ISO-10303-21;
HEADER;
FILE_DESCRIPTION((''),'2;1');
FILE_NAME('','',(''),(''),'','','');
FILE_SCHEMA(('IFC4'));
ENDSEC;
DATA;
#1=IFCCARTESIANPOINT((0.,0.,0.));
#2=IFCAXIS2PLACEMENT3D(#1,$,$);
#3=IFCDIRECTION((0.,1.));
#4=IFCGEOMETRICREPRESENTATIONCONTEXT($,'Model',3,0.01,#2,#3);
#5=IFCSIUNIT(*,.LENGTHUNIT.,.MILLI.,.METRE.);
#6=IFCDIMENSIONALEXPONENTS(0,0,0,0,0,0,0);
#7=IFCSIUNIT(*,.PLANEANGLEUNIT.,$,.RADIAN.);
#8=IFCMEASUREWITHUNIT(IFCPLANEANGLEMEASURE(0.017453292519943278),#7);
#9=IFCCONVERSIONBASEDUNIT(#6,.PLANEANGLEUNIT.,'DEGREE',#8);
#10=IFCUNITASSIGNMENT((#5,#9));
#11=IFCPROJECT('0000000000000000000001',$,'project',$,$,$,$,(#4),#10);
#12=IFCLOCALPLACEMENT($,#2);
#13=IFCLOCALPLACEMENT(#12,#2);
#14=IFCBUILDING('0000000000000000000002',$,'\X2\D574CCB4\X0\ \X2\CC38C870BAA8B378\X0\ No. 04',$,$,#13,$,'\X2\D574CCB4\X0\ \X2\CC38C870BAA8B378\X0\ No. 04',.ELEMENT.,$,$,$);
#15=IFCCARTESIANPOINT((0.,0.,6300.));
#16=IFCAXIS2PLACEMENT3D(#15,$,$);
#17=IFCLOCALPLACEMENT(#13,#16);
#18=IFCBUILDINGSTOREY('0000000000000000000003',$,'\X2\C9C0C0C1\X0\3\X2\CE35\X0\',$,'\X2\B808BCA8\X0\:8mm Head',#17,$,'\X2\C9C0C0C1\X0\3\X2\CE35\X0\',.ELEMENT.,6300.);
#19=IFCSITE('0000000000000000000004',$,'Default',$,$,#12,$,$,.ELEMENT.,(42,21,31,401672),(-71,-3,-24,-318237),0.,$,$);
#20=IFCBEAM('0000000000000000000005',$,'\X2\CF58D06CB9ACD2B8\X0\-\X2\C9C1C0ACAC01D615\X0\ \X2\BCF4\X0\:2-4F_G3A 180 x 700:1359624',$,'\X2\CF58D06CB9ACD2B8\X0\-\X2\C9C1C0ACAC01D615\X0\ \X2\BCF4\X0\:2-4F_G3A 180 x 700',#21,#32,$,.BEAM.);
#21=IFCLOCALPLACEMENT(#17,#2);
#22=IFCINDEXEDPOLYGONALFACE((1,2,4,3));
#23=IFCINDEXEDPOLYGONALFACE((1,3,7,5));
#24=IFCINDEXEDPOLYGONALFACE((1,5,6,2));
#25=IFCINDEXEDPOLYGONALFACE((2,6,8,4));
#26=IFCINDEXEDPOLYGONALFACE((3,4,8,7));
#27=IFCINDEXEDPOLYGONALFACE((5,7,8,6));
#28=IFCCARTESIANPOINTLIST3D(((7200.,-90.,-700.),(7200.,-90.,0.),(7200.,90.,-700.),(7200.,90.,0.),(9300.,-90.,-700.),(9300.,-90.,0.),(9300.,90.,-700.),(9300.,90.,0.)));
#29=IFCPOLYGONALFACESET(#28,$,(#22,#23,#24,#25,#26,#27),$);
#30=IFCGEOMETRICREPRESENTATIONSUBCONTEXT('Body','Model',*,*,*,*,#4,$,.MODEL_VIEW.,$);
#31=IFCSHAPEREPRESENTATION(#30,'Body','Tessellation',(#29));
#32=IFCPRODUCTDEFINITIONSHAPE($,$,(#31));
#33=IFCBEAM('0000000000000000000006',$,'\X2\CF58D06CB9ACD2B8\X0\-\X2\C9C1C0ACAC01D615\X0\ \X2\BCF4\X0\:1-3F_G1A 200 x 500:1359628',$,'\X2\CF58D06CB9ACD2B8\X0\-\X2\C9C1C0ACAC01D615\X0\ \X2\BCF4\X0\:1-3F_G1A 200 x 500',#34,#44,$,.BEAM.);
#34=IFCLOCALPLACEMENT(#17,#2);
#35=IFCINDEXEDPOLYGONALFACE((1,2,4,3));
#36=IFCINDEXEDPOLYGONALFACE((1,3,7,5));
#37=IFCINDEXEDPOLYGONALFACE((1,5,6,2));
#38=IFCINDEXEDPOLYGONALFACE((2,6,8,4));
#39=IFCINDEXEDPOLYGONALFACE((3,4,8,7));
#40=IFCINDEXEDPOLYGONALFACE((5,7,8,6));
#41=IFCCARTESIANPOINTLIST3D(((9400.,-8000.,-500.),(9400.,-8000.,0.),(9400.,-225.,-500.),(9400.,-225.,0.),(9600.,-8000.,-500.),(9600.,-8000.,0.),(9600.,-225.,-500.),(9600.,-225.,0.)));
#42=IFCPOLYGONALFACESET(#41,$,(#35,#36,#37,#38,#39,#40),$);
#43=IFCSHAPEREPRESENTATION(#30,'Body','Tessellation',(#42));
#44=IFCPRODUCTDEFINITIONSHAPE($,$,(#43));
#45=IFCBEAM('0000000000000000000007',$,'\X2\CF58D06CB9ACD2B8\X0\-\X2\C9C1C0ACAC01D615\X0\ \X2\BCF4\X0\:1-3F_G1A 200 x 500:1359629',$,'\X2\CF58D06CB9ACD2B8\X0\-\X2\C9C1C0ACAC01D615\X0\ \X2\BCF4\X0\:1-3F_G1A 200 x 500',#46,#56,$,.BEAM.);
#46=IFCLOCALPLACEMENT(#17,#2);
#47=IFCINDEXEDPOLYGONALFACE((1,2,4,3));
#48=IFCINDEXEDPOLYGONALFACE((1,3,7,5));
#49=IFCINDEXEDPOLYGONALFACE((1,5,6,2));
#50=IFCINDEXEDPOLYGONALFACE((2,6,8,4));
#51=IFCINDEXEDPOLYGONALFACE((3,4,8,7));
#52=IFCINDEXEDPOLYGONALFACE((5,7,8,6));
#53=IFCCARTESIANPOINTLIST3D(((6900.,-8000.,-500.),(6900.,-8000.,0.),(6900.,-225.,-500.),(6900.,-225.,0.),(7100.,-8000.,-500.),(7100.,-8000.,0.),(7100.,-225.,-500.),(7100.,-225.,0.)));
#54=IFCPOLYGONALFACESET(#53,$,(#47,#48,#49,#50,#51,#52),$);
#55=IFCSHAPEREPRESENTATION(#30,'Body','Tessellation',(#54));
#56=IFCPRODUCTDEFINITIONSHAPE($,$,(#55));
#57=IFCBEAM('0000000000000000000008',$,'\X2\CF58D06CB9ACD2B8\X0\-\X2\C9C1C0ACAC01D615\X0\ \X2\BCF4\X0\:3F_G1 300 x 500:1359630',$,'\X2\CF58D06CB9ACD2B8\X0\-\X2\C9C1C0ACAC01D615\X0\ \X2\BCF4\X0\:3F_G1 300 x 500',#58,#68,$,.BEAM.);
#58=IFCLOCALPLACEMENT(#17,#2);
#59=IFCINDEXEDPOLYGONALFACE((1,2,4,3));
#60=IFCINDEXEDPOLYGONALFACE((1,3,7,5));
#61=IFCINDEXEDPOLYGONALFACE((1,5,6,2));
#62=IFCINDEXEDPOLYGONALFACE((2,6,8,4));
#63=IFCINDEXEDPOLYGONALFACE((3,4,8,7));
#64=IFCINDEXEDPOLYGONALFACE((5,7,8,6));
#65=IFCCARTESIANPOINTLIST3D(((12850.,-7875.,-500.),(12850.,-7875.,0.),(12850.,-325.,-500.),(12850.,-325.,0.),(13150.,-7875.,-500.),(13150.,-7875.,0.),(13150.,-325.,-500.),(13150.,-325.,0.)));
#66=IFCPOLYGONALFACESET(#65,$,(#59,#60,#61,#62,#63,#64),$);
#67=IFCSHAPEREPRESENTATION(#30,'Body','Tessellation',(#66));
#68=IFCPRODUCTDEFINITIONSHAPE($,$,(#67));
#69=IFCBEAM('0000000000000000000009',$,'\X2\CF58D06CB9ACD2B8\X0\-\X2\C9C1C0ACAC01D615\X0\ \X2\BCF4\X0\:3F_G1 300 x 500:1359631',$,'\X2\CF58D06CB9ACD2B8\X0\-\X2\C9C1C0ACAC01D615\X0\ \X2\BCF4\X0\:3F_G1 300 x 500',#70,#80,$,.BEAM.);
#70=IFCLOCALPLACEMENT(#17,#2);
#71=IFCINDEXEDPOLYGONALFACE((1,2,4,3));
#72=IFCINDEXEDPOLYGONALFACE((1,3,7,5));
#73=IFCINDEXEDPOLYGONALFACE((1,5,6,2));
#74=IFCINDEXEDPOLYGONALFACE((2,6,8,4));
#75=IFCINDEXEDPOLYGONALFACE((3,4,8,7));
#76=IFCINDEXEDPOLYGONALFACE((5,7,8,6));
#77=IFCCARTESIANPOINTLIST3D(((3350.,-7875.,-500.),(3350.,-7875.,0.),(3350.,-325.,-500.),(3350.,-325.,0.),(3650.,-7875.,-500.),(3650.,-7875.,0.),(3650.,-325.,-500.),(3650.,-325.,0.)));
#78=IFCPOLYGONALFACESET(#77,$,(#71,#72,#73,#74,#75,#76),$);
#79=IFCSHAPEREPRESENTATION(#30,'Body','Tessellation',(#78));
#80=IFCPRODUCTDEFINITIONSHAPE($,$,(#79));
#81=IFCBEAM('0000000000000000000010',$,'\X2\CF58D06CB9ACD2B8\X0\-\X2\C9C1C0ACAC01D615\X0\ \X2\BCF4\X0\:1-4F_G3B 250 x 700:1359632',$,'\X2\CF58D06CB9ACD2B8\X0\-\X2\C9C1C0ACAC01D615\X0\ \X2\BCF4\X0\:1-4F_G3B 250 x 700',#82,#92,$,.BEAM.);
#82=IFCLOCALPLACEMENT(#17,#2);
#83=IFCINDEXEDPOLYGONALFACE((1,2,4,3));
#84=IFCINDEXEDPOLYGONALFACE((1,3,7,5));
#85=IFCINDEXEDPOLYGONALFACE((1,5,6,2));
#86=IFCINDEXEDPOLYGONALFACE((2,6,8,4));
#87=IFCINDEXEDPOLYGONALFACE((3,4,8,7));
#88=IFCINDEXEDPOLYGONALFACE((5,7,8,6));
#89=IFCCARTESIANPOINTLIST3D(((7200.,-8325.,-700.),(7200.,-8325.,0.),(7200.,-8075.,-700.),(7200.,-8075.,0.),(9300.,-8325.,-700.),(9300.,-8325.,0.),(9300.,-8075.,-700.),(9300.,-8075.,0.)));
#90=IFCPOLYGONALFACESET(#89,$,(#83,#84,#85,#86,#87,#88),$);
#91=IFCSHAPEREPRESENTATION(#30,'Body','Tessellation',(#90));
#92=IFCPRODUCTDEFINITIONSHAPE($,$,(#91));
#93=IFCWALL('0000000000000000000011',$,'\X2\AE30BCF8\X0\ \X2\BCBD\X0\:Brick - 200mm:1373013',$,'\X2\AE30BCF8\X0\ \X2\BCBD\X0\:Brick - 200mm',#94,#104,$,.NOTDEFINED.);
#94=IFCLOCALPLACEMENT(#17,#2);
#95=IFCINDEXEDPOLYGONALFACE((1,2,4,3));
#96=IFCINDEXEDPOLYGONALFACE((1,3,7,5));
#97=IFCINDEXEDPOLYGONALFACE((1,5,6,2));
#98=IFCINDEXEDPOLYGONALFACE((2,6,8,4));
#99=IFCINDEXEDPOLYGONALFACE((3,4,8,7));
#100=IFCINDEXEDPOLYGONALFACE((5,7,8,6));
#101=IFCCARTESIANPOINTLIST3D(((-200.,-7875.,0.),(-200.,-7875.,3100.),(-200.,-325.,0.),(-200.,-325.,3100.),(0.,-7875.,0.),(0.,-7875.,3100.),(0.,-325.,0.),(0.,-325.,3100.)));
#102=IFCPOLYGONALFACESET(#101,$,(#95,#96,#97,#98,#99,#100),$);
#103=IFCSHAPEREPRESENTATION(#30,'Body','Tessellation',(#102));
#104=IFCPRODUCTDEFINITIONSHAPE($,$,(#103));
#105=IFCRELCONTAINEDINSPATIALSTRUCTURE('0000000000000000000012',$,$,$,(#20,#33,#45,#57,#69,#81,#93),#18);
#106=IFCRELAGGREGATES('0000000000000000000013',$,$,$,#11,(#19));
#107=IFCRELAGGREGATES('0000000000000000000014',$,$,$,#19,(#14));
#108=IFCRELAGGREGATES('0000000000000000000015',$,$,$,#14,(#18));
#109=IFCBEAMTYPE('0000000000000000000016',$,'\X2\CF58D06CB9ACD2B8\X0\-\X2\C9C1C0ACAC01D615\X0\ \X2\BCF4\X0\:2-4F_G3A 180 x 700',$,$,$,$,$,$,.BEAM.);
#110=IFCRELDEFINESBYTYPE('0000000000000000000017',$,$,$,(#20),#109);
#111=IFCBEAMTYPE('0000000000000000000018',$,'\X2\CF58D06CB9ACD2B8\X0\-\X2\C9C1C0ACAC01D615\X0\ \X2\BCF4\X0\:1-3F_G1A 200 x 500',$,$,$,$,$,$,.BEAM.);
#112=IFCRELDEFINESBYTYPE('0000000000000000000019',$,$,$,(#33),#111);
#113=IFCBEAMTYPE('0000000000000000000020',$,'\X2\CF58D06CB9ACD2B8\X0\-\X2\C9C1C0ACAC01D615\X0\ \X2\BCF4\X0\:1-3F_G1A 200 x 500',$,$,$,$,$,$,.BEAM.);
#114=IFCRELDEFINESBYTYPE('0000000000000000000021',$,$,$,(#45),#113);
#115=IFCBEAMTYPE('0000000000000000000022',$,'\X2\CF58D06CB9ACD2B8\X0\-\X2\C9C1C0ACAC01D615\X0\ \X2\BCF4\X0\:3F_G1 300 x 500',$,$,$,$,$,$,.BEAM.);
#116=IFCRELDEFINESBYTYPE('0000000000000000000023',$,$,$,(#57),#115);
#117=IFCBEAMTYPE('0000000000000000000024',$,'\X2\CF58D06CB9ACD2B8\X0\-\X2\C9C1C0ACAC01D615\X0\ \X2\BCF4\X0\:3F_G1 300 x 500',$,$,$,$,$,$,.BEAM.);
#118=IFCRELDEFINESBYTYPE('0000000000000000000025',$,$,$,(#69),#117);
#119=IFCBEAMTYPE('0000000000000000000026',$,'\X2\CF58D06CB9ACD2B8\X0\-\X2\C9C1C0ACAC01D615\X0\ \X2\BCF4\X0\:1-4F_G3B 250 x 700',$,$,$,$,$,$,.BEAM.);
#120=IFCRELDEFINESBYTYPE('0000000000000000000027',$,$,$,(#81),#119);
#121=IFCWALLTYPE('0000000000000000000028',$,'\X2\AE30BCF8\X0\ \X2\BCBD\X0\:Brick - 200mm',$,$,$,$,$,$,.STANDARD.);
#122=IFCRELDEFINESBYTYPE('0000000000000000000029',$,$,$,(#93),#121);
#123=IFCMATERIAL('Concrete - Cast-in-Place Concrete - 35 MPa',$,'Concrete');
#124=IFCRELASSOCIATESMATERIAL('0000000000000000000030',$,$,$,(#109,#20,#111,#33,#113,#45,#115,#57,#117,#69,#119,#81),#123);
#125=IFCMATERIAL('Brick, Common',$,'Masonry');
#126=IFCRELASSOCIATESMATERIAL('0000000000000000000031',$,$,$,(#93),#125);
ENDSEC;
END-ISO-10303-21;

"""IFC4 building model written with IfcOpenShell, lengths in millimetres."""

from ifc_helpers import new_model, entity, si_unit, converted_unit, direction, frame, origin, place, context, subcontext, project, spatial, indexed_curve, outline, extrude, source, transform, mapped, material, type_object, type_shapes, element, save


model = new_model("IFC4")

# Units and contexts
model_context = context("Model", 3, precision=0.01, world=origin(), true_north=direction((0.0, 1.0)))
body_context = subcontext(model_context, "Body", "Model", "MODEL_VIEW")
ifc_project = project(units=[si_unit("LENGTHUNIT", "METRE", prefix="MILLI"), converted_unit("PLANEANGLEUNIT", "DEGREE", entity("IfcPlaneAngleMeasure", 0.017453292519943278), si_unit("PLANEANGLEUNIT", "RADIAN"), dimensions=[0, 0, 0, 0, 0, 0, 0])], contexts=[model_context])

# Site, building, storey
site_placement = place(None, origin())
site = spatial("IfcSite", under=ifc_project, at=site_placement, Name="Default", CompositionType="ELEMENT", RefLatitude=(42, 21, 31, 401672), RefLongitude=(-71, -3, -24, -318237), RefElevation=0.0)
building_placement = place(site_placement, origin())
building = spatial("IfcBuilding", under=site, at=building_placement, Name="해체 참조모델 No. 04", LongName="해체 참조모델 No. 04", CompositionType="ELEMENT")
storey_placement = place(building_placement, frame((0.0, 0.0, 6300.0)))
storey = spatial("IfcBuildingStorey", under=building, at=storey_placement, Name="지상3층", ObjectType="레벨:8mm Head", LongName="지상3층", CompositionType="ELEMENT", Elevation=6300.0)

# Beams
ifc_material_1 = material(Name="Concrete - Cast-in-Place Concrete - 35 MPa", Category="Concrete")
beam_type_1 = type_object("IfcBeamType", Name="콘크리트-직사각형 보:2-4F_G3A 180 x 700", PredefinedType="BEAM", material=ifc_material_1)
shared_shape_1 = source(origin(), body_context, "Body", "SweptSolid", [
    extrude(outline(indexed_curve([(-350.0, -90.0), (350.0, -90.0), (350.0, 90.0), (-350.0, 90.0), (-350.0, -90.0)], self_intersect=False)), frame((7200.0, 0.0, 5950.0), z_axis=(1.0, 0.0, 0.0), x_axis=(0.0, 0.0, -1.0)), (0.0, 0.0, 1.0), 2100.0),
])
type_shapes(beam_type_1, [shared_shape_1])
beam_1_placement = place(storey_placement, frame((0.0, 0.0, -6300.0)))
element("IfcBeam", 1, at=beam_1_placement, inside=storey, type_object=beam_type_1, material=ifc_material_1, Name="콘크리트-직사각형 보:2-4F_G3A 180 x 700:1359624", ObjectType="콘크리트-직사각형 보:2-4F_G3A 180 x 700", PredefinedType="BEAM", context=body_context, shape_type="MappedRepresentation", body=[
    mapped(shared_shape_1, transform((0.0, 0.0, 0.0), scale=1.0)),
])
beam_type_2 = type_object("IfcBeamType", Name="콘크리트-직사각형 보:1-3F_G1A 200 x 500", PredefinedType="BEAM", material=ifc_material_1)
shared_shape_2 = source(origin(), body_context, "Body", "SweptSolid", [
    extrude(outline(indexed_curve([(-100.0, -250.0), (100.0, -250.0), (100.0, 250.0), (-100.0, 250.0), (-100.0, -250.0)], self_intersect=False)), frame((9500.0, -225.0, 6050.0), z_axis=(0.0, -1.0, 0.0), x_axis=(-1.0, 0.0, 0.0)), (0.0, 0.0, 1.0), 7775.0),
])
type_shapes(beam_type_2, [shared_shape_2])
beam_2_placement = place(storey_placement, frame((0.0, 0.0, -6300.0)))
element("IfcBeam", 2, at=beam_2_placement, inside=storey, type_object=beam_type_2, material=ifc_material_1, Name="콘크리트-직사각형 보:1-3F_G1A 200 x 500:1359628", ObjectType="콘크리트-직사각형 보:1-3F_G1A 200 x 500", PredefinedType="BEAM", context=body_context, shape_type="MappedRepresentation", body=[
    mapped(shared_shape_2, transform((0.0, 0.0, 0.0), scale=1.0)),
])
beam_type_3 = type_object("IfcBeamType", Name="콘크리트-직사각형 보:1-3F_G1A 200 x 500", PredefinedType="BEAM", material=ifc_material_1)
shared_shape_3 = source(origin(), body_context, "Body", "SweptSolid", [
    extrude(outline(indexed_curve([(-100.0, -250.0), (100.0, -250.0), (100.0, 250.0), (-100.0, 250.0), (-100.0, -250.0)], self_intersect=False)), frame((7000.0, -225.0, 6050.0), z_axis=(0.0, -1.0, 0.0), x_axis=(-1.0, 0.0, 0.0)), (0.0, 0.0, 1.0), 7775.0),
])
type_shapes(beam_type_3, [shared_shape_3])
beam_3_placement = place(storey_placement, frame((0.0, 0.0, -6300.0)))
element("IfcBeam", 3, at=beam_3_placement, inside=storey, type_object=beam_type_3, material=ifc_material_1, Name="콘크리트-직사각형 보:1-3F_G1A 200 x 500:1359629", ObjectType="콘크리트-직사각형 보:1-3F_G1A 200 x 500", PredefinedType="BEAM", context=body_context, shape_type="MappedRepresentation", body=[
    mapped(shared_shape_3, transform((0.0, 0.0, 0.0), scale=1.0)),
])
beam_type_4 = type_object("IfcBeamType", Name="콘크리트-직사각형 보:3F_G1 300 x 500", PredefinedType="BEAM", material=ifc_material_1)
shared_shape_4 = source(origin(), body_context, "Body", "SweptSolid", [
    extrude(outline(indexed_curve([(-150.0, -250.0), (150.0, -250.0), (150.0, 250.0), (-150.0, 250.0), (-150.0, -250.0)], self_intersect=False)), frame((13000.0, -325.0, 6050.0), z_axis=(0.0, -1.0, 0.0), x_axis=(-1.0, 0.0, 0.0)), (0.0, 0.0, 1.0), 7550.0),
])
type_shapes(beam_type_4, [shared_shape_4])
beam_4_placement = place(storey_placement, frame((0.0, 0.0, -6300.0)))
element("IfcBeam", 4, at=beam_4_placement, inside=storey, type_object=beam_type_4, material=ifc_material_1, Name="콘크리트-직사각형 보:3F_G1 300 x 500:1359630", ObjectType="콘크리트-직사각형 보:3F_G1 300 x 500", PredefinedType="BEAM", context=body_context, shape_type="MappedRepresentation", body=[
    mapped(shared_shape_4, transform((0.0, 0.0, 0.0), scale=1.0)),
])
beam_type_5 = type_object("IfcBeamType", Name="콘크리트-직사각형 보:3F_G1 300 x 500", PredefinedType="BEAM", material=ifc_material_1)
shared_shape_5 = source(origin(), body_context, "Body", "SweptSolid", [
    extrude(outline(indexed_curve([(-150.0, -250.0), (150.0, -250.0), (150.0, 250.0), (-150.0, 250.0), (-150.0, -250.0)], self_intersect=False)), frame((3500.0, -325.0, 6050.0), z_axis=(0.0, -1.0, 0.0), x_axis=(-1.0, 0.0, 0.0)), (0.0, 0.0, 1.0), 7550.0),
])
type_shapes(beam_type_5, [shared_shape_5])
beam_5_placement = place(storey_placement, frame((0.0, 0.0, -6300.0)))
element("IfcBeam", 5, at=beam_5_placement, inside=storey, type_object=beam_type_5, material=ifc_material_1, Name="콘크리트-직사각형 보:3F_G1 300 x 500:1359631", ObjectType="콘크리트-직사각형 보:3F_G1 300 x 500", PredefinedType="BEAM", context=body_context, shape_type="MappedRepresentation", body=[
    mapped(shared_shape_5, transform((0.0, 0.0, 0.0), scale=1.0)),
])
beam_type_6 = type_object("IfcBeamType", Name="콘크리트-직사각형 보:1-4F_G3B 250 x 700", PredefinedType="BEAM", material=ifc_material_1)
shared_shape_6 = source(origin(), body_context, "Body", "SweptSolid", [
    extrude(outline(indexed_curve([(-350.0, -125.0), (350.0, -125.0), (350.0, 125.0), (-350.0, 125.0), (-350.0, -125.0)], self_intersect=False)), frame((7200.0, -8200.0, 5950.0), z_axis=(1.0, 0.0, 0.0), x_axis=(0.0, 0.0, -1.0)), (0.0, 0.0, 1.0), 2100.0),
])
type_shapes(beam_type_6, [shared_shape_6])
beam_6_placement = place(storey_placement, frame((0.0, 0.0, -6300.0)))
element("IfcBeam", 6, at=beam_6_placement, inside=storey, type_object=beam_type_6, material=ifc_material_1, Name="콘크리트-직사각형 보:1-4F_G3B 250 x 700:1359632", ObjectType="콘크리트-직사각형 보:1-4F_G3B 250 x 700", PredefinedType="BEAM", context=body_context, shape_type="MappedRepresentation", body=[
    mapped(shared_shape_6, transform((0.0, 0.0, 0.0), scale=1.0)),
])

# Wall
ifc_material_2 = material(Name="Brick, Common", Category="Masonry")
wall_type = type_object("IfcWallType", Name="기본 벽:Brick - 200mm", PredefinedType="STANDARD")
wall_placement = place(storey_placement, frame((-100.0, -7875.0, 0.0), z_axis=(0.0, 0.0, 1.0), x_axis=(0.0, 1.0, 0.0)))
element("IfcWall", 7, at=wall_placement, inside=storey, type_object=wall_type, material=ifc_material_2, Name="기본 벽:Brick - 200mm:1373013", ObjectType="기본 벽:Brick - 200mm", PredefinedType="NOTDEFINED", context=body_context, shape_type="SweptSolid", body=[
    extrude(outline(indexed_curve([(7550.0, 100.0), (0.0, 100.0), (0.0, -100.0), (7550.0, -100.0), (7550.0, 100.0)], self_intersect=False)), origin(), (0.0, 0.0, 1.0), 3100.0),
])

save(model, "model.ifc")
